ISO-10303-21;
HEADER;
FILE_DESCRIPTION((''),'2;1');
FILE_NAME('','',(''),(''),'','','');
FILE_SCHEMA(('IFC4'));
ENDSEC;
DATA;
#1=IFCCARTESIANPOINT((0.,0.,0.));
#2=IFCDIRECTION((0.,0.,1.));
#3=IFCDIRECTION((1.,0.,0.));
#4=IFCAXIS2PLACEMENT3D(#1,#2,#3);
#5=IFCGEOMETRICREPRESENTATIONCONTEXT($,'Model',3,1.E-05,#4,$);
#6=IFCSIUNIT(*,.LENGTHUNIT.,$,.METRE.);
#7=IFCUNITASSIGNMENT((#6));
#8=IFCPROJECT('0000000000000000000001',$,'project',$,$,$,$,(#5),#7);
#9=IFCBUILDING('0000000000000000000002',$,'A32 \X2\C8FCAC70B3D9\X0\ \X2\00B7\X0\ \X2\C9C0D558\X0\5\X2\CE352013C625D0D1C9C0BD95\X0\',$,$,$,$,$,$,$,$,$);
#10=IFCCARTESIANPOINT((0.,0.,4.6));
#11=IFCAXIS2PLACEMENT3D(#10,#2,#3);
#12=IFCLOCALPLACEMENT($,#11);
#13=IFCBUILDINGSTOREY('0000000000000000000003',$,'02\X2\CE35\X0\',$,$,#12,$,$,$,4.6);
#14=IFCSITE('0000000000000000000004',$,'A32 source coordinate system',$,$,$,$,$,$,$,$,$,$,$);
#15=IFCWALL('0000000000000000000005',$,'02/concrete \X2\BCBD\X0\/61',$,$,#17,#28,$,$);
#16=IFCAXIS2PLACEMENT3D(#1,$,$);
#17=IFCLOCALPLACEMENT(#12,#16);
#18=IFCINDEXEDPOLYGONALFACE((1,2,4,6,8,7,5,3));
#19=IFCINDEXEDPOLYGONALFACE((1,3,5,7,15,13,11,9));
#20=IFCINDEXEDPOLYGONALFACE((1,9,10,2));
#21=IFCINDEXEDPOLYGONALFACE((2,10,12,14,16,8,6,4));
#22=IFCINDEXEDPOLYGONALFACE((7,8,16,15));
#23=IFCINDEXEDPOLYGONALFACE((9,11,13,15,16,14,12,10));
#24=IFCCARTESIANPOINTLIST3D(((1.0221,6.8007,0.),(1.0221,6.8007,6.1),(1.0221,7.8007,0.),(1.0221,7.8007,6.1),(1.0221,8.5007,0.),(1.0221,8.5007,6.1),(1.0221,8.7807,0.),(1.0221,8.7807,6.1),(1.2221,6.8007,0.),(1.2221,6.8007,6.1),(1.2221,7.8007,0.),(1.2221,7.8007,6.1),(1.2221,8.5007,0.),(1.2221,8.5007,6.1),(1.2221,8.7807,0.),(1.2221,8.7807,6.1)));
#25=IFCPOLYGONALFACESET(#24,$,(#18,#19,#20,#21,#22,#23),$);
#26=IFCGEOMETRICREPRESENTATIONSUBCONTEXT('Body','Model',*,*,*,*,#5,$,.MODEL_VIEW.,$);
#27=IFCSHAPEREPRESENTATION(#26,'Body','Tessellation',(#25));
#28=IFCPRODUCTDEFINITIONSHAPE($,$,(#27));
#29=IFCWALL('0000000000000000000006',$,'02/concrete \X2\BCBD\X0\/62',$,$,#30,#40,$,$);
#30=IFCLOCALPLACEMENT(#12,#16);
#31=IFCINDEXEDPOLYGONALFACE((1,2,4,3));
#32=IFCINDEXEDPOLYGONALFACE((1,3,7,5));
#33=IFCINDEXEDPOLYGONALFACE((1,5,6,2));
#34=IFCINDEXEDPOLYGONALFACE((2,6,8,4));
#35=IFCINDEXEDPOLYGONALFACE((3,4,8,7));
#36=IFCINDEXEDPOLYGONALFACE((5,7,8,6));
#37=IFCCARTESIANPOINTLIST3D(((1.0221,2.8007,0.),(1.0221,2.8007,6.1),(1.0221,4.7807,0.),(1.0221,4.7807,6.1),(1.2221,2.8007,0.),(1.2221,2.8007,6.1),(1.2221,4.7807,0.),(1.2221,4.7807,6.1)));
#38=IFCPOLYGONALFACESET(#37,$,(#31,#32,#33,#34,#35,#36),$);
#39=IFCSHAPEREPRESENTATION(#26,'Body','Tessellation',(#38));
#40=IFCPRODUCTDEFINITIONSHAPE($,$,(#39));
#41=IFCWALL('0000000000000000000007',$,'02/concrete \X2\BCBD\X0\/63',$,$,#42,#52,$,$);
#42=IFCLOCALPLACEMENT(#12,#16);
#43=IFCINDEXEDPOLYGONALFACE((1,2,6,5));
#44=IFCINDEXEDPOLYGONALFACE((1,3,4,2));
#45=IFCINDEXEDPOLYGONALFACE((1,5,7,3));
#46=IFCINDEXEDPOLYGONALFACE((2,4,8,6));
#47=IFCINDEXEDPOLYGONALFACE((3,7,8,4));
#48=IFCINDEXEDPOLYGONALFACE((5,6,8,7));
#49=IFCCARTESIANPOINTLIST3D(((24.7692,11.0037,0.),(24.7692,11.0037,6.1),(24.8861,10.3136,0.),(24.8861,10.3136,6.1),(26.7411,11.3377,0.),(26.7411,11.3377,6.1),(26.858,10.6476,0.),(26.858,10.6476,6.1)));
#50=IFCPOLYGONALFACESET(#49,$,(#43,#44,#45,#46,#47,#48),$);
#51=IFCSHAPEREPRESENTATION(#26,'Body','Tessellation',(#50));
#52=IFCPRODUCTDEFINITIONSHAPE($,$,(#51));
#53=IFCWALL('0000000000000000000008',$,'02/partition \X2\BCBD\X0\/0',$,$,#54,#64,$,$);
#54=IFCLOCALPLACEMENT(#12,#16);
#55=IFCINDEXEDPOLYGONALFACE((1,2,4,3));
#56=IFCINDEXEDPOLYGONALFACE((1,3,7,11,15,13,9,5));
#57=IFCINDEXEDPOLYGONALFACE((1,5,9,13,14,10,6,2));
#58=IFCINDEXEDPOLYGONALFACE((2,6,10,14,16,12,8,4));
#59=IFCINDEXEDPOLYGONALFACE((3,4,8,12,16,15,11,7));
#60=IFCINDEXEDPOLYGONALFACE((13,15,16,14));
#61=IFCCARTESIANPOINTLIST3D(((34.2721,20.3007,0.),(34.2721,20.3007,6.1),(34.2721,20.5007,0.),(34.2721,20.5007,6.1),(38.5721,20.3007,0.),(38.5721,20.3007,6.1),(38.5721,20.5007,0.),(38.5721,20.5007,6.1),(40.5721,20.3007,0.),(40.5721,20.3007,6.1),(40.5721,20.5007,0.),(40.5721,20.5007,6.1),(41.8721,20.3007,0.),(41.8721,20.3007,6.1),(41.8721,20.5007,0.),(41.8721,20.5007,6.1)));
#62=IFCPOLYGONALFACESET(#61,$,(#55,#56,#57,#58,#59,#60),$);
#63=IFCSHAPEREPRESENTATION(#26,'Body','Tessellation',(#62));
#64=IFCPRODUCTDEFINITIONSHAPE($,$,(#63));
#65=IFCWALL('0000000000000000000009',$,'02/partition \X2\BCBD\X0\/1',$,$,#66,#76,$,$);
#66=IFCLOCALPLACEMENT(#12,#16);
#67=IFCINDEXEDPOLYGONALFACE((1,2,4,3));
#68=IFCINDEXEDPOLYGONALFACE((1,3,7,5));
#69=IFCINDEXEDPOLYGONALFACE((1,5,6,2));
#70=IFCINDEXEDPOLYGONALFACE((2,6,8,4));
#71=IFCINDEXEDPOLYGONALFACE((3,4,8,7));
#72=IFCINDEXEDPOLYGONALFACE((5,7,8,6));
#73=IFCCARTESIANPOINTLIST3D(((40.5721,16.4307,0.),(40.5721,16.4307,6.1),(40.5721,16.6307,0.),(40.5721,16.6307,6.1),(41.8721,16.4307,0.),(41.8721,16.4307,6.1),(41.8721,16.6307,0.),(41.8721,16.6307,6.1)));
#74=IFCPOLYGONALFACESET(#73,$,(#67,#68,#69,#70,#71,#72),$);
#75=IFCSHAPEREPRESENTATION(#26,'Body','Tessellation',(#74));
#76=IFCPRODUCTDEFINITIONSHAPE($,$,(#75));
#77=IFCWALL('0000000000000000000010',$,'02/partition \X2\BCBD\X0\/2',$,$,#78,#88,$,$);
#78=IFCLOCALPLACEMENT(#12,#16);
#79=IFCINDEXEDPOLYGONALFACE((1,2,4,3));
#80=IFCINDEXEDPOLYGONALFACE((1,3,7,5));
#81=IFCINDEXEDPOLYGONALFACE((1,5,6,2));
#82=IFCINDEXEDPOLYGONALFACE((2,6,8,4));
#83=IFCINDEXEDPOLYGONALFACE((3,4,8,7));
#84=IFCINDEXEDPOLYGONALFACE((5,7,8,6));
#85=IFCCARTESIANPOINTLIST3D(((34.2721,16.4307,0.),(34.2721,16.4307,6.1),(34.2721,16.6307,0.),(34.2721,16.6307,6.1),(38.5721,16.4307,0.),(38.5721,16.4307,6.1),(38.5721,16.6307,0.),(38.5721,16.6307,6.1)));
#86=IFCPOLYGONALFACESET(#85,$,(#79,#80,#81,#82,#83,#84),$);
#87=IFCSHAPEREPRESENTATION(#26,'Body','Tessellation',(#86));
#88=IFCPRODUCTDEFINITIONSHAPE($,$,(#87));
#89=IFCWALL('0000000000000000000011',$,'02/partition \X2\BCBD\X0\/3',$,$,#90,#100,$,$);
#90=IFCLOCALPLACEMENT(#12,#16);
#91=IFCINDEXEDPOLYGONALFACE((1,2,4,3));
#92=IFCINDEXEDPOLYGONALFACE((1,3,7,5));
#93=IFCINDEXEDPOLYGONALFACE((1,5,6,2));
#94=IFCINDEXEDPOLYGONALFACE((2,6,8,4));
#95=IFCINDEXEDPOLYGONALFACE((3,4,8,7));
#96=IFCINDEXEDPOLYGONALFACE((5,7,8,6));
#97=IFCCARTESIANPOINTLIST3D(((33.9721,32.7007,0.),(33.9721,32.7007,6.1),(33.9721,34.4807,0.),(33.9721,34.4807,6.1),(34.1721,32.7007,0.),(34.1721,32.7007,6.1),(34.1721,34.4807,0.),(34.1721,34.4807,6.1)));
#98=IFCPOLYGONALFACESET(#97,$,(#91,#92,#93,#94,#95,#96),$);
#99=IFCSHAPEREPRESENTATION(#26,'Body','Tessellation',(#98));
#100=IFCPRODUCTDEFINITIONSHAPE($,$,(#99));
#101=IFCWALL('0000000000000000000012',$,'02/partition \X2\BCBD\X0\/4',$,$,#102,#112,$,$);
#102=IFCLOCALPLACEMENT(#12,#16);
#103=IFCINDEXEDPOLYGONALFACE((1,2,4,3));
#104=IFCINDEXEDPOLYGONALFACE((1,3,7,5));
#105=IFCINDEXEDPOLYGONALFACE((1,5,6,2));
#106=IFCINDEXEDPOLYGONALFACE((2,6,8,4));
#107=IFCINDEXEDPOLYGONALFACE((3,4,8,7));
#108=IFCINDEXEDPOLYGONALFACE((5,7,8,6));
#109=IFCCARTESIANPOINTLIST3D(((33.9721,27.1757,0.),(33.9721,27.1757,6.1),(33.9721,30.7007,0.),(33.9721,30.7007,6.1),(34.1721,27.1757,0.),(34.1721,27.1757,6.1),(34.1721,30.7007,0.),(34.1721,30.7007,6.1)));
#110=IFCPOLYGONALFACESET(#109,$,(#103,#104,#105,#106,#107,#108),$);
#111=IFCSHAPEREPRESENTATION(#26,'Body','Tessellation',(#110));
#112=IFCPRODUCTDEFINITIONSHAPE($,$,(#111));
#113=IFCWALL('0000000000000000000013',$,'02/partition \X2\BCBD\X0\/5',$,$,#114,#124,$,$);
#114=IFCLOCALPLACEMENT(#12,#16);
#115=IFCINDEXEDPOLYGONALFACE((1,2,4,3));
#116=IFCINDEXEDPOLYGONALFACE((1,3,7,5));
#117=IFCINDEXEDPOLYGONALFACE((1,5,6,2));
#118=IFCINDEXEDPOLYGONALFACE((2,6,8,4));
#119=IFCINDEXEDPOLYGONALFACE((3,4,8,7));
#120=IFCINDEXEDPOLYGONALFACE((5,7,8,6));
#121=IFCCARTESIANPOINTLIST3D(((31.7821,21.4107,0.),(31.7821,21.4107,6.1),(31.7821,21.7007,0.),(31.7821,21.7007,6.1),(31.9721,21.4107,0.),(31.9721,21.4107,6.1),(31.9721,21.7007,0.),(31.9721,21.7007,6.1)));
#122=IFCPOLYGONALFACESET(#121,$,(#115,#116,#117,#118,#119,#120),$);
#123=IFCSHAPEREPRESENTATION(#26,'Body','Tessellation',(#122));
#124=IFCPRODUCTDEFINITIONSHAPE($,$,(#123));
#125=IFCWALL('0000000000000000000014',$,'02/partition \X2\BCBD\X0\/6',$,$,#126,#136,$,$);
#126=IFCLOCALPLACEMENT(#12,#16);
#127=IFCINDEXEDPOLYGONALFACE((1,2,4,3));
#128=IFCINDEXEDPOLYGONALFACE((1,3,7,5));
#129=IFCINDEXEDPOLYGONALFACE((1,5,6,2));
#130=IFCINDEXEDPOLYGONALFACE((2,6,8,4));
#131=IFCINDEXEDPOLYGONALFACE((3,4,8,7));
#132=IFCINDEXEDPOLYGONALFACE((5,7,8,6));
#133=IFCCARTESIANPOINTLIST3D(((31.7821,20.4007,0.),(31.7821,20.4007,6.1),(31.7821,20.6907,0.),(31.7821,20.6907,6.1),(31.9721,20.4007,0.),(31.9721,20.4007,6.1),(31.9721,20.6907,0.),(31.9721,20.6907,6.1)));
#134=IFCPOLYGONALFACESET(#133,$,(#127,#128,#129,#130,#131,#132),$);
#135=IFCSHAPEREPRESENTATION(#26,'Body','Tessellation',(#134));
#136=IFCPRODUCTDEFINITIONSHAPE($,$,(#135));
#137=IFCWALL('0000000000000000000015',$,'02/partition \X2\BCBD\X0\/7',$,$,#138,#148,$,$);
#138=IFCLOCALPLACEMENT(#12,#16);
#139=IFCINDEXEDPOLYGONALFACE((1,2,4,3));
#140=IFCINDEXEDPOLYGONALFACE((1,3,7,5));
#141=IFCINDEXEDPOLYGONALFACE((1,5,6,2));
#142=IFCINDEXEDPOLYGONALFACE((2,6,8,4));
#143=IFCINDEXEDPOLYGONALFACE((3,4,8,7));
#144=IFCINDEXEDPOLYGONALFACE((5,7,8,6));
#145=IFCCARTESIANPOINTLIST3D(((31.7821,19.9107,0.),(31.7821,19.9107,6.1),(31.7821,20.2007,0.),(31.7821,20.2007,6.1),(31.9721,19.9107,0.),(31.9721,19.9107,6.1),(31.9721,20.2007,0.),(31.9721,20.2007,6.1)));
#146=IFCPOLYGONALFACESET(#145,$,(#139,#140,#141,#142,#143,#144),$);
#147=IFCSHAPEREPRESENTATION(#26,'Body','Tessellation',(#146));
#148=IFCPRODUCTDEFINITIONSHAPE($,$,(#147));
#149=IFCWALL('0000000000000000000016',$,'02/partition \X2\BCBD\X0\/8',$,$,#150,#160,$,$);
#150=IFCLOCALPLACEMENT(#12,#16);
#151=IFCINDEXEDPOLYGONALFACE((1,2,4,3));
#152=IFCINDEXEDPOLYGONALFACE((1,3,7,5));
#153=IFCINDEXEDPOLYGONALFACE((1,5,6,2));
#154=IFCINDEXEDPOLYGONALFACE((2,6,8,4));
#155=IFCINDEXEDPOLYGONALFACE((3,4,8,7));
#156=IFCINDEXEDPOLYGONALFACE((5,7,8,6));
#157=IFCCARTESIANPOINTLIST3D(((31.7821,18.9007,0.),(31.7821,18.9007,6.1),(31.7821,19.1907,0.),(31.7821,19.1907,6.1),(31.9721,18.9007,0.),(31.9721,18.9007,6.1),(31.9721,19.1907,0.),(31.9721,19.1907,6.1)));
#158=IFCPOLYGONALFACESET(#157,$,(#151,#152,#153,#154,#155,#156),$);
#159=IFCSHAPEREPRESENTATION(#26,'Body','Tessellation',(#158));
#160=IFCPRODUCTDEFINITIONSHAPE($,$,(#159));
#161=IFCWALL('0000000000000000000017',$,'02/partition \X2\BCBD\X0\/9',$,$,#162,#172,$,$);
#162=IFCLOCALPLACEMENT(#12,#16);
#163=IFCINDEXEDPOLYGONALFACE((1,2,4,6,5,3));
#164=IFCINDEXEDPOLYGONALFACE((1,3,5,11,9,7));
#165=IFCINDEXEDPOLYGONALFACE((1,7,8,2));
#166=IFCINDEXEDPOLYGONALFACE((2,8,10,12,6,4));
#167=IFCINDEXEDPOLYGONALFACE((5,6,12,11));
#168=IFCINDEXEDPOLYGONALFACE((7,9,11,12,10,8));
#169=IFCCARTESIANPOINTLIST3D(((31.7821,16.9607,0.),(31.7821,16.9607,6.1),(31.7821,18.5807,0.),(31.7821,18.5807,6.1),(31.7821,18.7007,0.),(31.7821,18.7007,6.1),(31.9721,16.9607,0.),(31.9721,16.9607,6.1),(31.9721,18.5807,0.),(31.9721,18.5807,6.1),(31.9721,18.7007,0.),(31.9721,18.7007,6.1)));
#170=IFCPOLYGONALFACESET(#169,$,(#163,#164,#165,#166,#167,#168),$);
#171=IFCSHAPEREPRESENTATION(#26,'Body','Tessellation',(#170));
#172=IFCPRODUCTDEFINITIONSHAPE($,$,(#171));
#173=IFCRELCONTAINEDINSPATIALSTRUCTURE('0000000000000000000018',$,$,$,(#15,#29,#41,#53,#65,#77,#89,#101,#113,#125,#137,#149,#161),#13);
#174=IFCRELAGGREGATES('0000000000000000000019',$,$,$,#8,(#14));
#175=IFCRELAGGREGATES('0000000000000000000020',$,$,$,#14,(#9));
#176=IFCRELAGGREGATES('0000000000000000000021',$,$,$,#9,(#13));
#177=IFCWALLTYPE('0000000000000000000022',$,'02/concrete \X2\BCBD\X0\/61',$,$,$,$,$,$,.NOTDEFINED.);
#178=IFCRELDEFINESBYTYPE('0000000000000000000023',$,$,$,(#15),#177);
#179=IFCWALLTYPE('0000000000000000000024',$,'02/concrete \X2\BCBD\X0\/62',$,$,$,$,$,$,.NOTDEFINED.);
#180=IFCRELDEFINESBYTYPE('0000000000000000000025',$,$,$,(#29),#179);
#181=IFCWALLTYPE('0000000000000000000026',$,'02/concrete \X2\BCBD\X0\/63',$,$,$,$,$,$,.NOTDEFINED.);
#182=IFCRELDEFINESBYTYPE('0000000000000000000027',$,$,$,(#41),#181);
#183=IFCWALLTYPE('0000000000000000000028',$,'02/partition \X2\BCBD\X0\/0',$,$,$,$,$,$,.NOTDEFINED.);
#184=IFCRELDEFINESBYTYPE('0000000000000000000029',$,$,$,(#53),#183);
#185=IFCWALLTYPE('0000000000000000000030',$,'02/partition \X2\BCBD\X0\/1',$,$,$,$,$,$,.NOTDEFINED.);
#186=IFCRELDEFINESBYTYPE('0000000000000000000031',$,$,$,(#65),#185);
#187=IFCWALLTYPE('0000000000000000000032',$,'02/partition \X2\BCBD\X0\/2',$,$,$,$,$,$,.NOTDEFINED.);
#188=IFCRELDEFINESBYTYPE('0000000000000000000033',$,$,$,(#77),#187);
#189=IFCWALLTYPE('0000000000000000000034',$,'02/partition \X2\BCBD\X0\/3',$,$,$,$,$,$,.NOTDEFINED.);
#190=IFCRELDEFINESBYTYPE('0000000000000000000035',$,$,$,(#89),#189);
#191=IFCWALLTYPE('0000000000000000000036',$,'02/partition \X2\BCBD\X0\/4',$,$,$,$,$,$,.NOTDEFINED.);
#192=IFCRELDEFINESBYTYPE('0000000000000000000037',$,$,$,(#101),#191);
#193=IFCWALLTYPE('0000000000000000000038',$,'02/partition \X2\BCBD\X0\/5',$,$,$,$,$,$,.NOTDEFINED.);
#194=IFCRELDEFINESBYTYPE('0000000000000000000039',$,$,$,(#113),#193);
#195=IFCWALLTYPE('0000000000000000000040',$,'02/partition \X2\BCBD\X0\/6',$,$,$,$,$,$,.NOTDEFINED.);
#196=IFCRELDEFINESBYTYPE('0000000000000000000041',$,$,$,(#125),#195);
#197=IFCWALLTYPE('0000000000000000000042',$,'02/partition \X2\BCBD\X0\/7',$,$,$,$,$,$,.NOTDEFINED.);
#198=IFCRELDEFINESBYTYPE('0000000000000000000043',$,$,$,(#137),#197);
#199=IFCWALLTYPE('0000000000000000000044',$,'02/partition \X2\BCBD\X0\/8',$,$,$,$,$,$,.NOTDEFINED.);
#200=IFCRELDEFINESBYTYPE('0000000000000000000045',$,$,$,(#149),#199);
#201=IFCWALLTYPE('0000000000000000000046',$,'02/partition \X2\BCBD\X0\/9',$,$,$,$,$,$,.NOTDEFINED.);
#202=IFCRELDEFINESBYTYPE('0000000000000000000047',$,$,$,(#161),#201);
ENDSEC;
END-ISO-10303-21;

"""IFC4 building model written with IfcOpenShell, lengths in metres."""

from ifc_helpers import new_model, si_unit, frame, origin, origin_with_axes, place, context, subcontext, project, spatial, polyline, outline, extrude, source, transform, mapped, type_object, type_shapes, element, save


model = new_model("IFC4")

# Units and contexts
model_context = context("Model", 3, precision=1e-05, world=origin_with_axes())
body_context = subcontext(model_context, "Body", "Model", "MODEL_VIEW")
ifc_project = project(units=[si_unit("LENGTHUNIT", "METRE")], contexts=[model_context])

# Site, building, storey
site = spatial("IfcSite", under=ifc_project, Name="A32 source coordinate system")
building = spatial("IfcBuilding", under=site, Name="A32 주거동 · 지하5층–옥탑지붕")
storey_placement = place(None, frame((0.0, 0.0, 4.6), z_axis=(0.0, 0.0, 1.0), x_axis=(1.0, 0.0, 0.0)))
storey = spatial("IfcBuildingStorey", under=building, at=storey_placement, Name="02층", Elevation=4.6)

# Walls
wall_type_1 = type_object("IfcWallType", Name="02/concrete 벽/61", PredefinedType="NOTDEFINED")
shared_shape_1 = source(origin(), body_context, "Body", "SweptSolid", [
    extrude(outline(polyline([(1.0221, 7.8007), (1.0221, 8.5007), (1.0221, 8.7807), (1.2221, 8.7807), (1.2221, 8.5007), (1.2221, 7.8007), (1.2221, 6.8007), (1.0221, 6.8007), (1.0221, 7.8007)])), origin(), (0.0, 0.0, 1.0), 6.1),
])
type_shapes(wall_type_1, [shared_shape_1])
wall_1_placement = place(storey_placement, origin_with_axes())
element("IfcWall", 1, at=wall_1_placement, inside=storey, type_object=wall_type_1, Name="02/concrete 벽/61", context=body_context, shape_type="MappedRepresentation", body=[
    mapped(shared_shape_1, transform((0.0, 0.0, 0.0), scale=1.0)),
])
wall_type_2 = type_object("IfcWallType", Name="02/concrete 벽/62", PredefinedType="NOTDEFINED")
shared_shape_2 = source(origin(), body_context, "Body", "SweptSolid", [
    extrude(outline(polyline([(1.0221, 4.7807), (1.2221, 4.7807), (1.2221, 2.8007), (1.0221, 2.8007), (1.0221, 4.7807)])), origin(), (0.0, 0.0, 1.0), 6.1),
])
type_shapes(wall_type_2, [shared_shape_2])
wall_2_placement = place(storey_placement, origin_with_axes())
element("IfcWall", 2, at=wall_2_placement, inside=storey, type_object=wall_type_2, Name="02/concrete 벽/62", context=body_context, shape_type="MappedRepresentation", body=[
    mapped(shared_shape_2, transform((0.0, 0.0, 0.0), scale=1.0)),
])
wall_type_3 = type_object("IfcWallType", Name="02/concrete 벽/63", PredefinedType="NOTDEFINED")
shared_shape_3 = source(origin(), body_context, "Body", "SweptSolid", [
    extrude(outline(polyline([(24.8861, 10.3136), (24.7692, 11.0037), (26.7411, 11.3377), (26.858, 10.6476), (24.8861, 10.3136)])), origin(), (0.0, 0.0, 1.0), 6.1),
])
type_shapes(wall_type_3, [shared_shape_3])
wall_3_placement = place(storey_placement, origin_with_axes())
element("IfcWall", 3, at=wall_3_placement, inside=storey, type_object=wall_type_3, Name="02/concrete 벽/63", context=body_context, shape_type="MappedRepresentation", body=[
    mapped(shared_shape_3, transform((0.0, 0.0, 0.0), scale=1.0)),
])
wall_type_4 = type_object("IfcWallType", Name="02/partition 벽/0", PredefinedType="NOTDEFINED")
shared_shape_4 = source(origin(), body_context, "Body", "SweptSolid", [
    extrude(outline(polyline([(40.5721, 20.3007), (38.5721, 20.3007), (34.2721, 20.3007), (34.2721, 20.5007), (38.5721, 20.5007), (40.5721, 20.5007), (41.8721, 20.5007), (41.8721, 20.3007), (40.5721, 20.3007)])), origin(), (0.0, 0.0, 1.0), 6.1),
])
type_shapes(wall_type_4, [shared_shape_4])
wall_4_placement = place(storey_placement, origin_with_axes())
element("IfcWall", 4, at=wall_4_placement, inside=storey, type_object=wall_type_4, Name="02/partition 벽/0", context=body_context, shape_type="MappedRepresentation", body=[
    mapped(shared_shape_4, transform((0.0, 0.0, 0.0), scale=1.0)),
])
wall_type_5 = type_object("IfcWallType", Name="02/partition 벽/1", PredefinedType="NOTDEFINED")
shared_shape_5 = source(origin(), body_context, "Body", "SweptSolid", [
    extrude(outline(polyline([(41.8721, 16.6307), (41.8721, 16.4307), (40.5721, 16.4307), (40.5721, 16.6307), (41.8721, 16.6307)])), origin(), (0.0, 0.0, 1.0), 6.1),
])
type_shapes(wall_type_5, [shared_shape_5])
wall_5_placement = place(storey_placement, origin_with_axes())
element("IfcWall", 5, at=wall_5_placement, inside=storey, type_object=wall_type_5, Name="02/partition 벽/1", context=body_context, shape_type="MappedRepresentation", body=[
    mapped(shared_shape_5, transform((0.0, 0.0, 0.0), scale=1.0)),
])
wall_type_6 = type_object("IfcWallType", Name="02/partition 벽/2", PredefinedType="NOTDEFINED")
shared_shape_6 = source(origin(), body_context, "Body", "SweptSolid", [
    extrude(outline(polyline([(38.5721, 16.6307), (38.5721, 16.4307), (34.2721, 16.4307), (34.2721, 16.6307), (38.5721, 16.6307)])), origin(), (0.0, 0.0, 1.0), 6.1),
])
type_shapes(wall_type_6, [shared_shape_6])
wall_6_placement = place(storey_placement, origin_with_axes())
element("IfcWall", 6, at=wall_6_placement, inside=storey, type_object=wall_type_6, Name="02/partition 벽/2", context=body_context, shape_type="MappedRepresentation", body=[
    mapped(shared_shape_6, transform((0.0, 0.0, 0.0), scale=1.0)),
])
wall_type_7 = type_object("IfcWallType", Name="02/partition 벽/3", PredefinedType="NOTDEFINED")
shared_shape_7 = source(origin(), body_context, "Body", "SweptSolid", [
    extrude(outline(polyline([(34.1721, 34.4807), (34.1721, 32.7007), (33.9721, 32.7007), (33.9721, 34.4807), (34.1721, 34.4807)])), origin(), (0.0, 0.0, 1.0), 6.1),
])
type_shapes(wall_type_7, [shared_shape_7])
wall_7_placement = place(storey_placement, origin_with_axes())
element("IfcWall", 7, at=wall_7_placement, inside=storey, type_object=wall_type_7, Name="02/partition 벽/3", context=body_context, shape_type="MappedRepresentation", body=[
    mapped(shared_shape_7, transform((0.0, 0.0, 0.0), scale=1.0)),
])
wall_type_8 = type_object("IfcWallType", Name="02/partition 벽/4", PredefinedType="NOTDEFINED")
shared_shape_8 = source(origin(), body_context, "Body", "SweptSolid", [
    extrude(outline(polyline([(34.1721, 30.7007), (34.1721, 27.1757), (33.9721, 27.1757), (33.9721, 30.7007), (34.1721, 30.7007)])), origin(), (0.0, 0.0, 1.0), 6.1),
])
type_shapes(wall_type_8, [shared_shape_8])
wall_8_placement = place(storey_placement, origin_with_axes())
element("IfcWall", 8, at=wall_8_placement, inside=storey, type_object=wall_type_8, Name="02/partition 벽/4", context=body_context, shape_type="MappedRepresentation", body=[
    mapped(shared_shape_8, transform((0.0, 0.0, 0.0), scale=1.0)),
])
wall_type_9 = type_object("IfcWallType", Name="02/partition 벽/5", PredefinedType="NOTDEFINED")
shared_shape_9 = source(origin(), body_context, "Body", "SweptSolid", [
    extrude(outline(polyline([(31.7821, 21.7007), (31.9721, 21.7007), (31.9721, 21.4107), (31.7821, 21.4107), (31.7821, 21.7007)])), origin(), (0.0, 0.0, 1.0), 6.1),
])
type_shapes(wall_type_9, [shared_shape_9])
wall_9_placement = place(storey_placement, origin_with_axes())
element("IfcWall", 9, at=wall_9_placement, inside=storey, type_object=wall_type_9, Name="02/partition 벽/5", context=body_context, shape_type="MappedRepresentation", body=[
    mapped(shared_shape_9, transform((0.0, 0.0, 0.0), scale=1.0)),
])
wall_type_10 = type_object("IfcWallType", Name="02/partition 벽/6", PredefinedType="NOTDEFINED")
shared_shape_10 = source(origin(), body_context, "Body", "SweptSolid", [
    extrude(outline(polyline([(31.9721, 20.6907), (31.9721, 20.4007), (31.7821, 20.4007), (31.7821, 20.6907), (31.9721, 20.6907)])), origin(), (0.0, 0.0, 1.0), 6.1),
])
type_shapes(wall_type_10, [shared_shape_10])
wall_10_placement = place(storey_placement, origin_with_axes())
element("IfcWall", 10, at=wall_10_placement, inside=storey, type_object=wall_type_10, Name="02/partition 벽/6", context=body_context, shape_type="MappedRepresentation", body=[
    mapped(shared_shape_10, transform((0.0, 0.0, 0.0), scale=1.0)),
])
wall_type_11 = type_object("IfcWallType", Name="02/partition 벽/7", PredefinedType="NOTDEFINED")
shared_shape_11 = source(origin(), body_context, "Body", "SweptSolid", [
    extrude(outline(polyline([(31.9721, 20.2007), (31.9721, 19.9107), (31.7821, 19.9107), (31.7821, 20.2007), (31.9721, 20.2007)])), origin(), (0.0, 0.0, 1.0), 6.1),
])
type_shapes(wall_type_11, [shared_shape_11])
wall_11_placement = place(storey_placement, origin_with_axes())
element("IfcWall", 11, at=wall_11_placement, inside=storey, type_object=wall_type_11, Name="02/partition 벽/7", context=body_context, shape_type="MappedRepresentation", body=[
    mapped(shared_shape_11, transform((0.0, 0.0, 0.0), scale=1.0)),
])
wall_type_12 = type_object("IfcWallType", Name="02/partition 벽/8", PredefinedType="NOTDEFINED")
shared_shape_12 = source(origin(), body_context, "Body", "SweptSolid", [
    extrude(outline(polyline([(31.9721, 19.1907), (31.9721, 18.9007), (31.7821, 18.9007), (31.7821, 19.1907), (31.9721, 19.1907)])), origin(), (0.0, 0.0, 1.0), 6.1),
])
type_shapes(wall_type_12, [shared_shape_12])
wall_12_placement = place(storey_placement, origin_with_axes())
element("IfcWall", 12, at=wall_12_placement, inside=storey, type_object=wall_type_12, Name="02/partition 벽/8", context=body_context, shape_type="MappedRepresentation", body=[
    mapped(shared_shape_12, transform((0.0, 0.0, 0.0), scale=1.0)),
])
wall_type_13 = type_object("IfcWallType", Name="02/partition 벽/9", PredefinedType="NOTDEFINED")
shared_shape_13 = source(origin(), body_context, "Body", "SweptSolid", [
    extrude(outline(polyline([(31.7821, 18.7007), (31.9721, 18.7007), (31.9721, 18.5807), (31.9721, 16.9607), (31.7821, 16.9607), (31.7821, 18.5807), (31.7821, 18.7007)])), origin(), (0.0, 0.0, 1.0), 6.1),
])
type_shapes(wall_type_13, [shared_shape_13])
wall_13_placement = place(storey_placement, origin_with_axes())
element("IfcWall", 13, at=wall_13_placement, inside=storey, type_object=wall_type_13, Name="02/partition 벽/9", context=body_context, shape_type="MappedRepresentation", body=[
    mapped(shared_shape_13, transform((0.0, 0.0, 0.0), scale=1.0)),
])

save(model, "model.ifc")
